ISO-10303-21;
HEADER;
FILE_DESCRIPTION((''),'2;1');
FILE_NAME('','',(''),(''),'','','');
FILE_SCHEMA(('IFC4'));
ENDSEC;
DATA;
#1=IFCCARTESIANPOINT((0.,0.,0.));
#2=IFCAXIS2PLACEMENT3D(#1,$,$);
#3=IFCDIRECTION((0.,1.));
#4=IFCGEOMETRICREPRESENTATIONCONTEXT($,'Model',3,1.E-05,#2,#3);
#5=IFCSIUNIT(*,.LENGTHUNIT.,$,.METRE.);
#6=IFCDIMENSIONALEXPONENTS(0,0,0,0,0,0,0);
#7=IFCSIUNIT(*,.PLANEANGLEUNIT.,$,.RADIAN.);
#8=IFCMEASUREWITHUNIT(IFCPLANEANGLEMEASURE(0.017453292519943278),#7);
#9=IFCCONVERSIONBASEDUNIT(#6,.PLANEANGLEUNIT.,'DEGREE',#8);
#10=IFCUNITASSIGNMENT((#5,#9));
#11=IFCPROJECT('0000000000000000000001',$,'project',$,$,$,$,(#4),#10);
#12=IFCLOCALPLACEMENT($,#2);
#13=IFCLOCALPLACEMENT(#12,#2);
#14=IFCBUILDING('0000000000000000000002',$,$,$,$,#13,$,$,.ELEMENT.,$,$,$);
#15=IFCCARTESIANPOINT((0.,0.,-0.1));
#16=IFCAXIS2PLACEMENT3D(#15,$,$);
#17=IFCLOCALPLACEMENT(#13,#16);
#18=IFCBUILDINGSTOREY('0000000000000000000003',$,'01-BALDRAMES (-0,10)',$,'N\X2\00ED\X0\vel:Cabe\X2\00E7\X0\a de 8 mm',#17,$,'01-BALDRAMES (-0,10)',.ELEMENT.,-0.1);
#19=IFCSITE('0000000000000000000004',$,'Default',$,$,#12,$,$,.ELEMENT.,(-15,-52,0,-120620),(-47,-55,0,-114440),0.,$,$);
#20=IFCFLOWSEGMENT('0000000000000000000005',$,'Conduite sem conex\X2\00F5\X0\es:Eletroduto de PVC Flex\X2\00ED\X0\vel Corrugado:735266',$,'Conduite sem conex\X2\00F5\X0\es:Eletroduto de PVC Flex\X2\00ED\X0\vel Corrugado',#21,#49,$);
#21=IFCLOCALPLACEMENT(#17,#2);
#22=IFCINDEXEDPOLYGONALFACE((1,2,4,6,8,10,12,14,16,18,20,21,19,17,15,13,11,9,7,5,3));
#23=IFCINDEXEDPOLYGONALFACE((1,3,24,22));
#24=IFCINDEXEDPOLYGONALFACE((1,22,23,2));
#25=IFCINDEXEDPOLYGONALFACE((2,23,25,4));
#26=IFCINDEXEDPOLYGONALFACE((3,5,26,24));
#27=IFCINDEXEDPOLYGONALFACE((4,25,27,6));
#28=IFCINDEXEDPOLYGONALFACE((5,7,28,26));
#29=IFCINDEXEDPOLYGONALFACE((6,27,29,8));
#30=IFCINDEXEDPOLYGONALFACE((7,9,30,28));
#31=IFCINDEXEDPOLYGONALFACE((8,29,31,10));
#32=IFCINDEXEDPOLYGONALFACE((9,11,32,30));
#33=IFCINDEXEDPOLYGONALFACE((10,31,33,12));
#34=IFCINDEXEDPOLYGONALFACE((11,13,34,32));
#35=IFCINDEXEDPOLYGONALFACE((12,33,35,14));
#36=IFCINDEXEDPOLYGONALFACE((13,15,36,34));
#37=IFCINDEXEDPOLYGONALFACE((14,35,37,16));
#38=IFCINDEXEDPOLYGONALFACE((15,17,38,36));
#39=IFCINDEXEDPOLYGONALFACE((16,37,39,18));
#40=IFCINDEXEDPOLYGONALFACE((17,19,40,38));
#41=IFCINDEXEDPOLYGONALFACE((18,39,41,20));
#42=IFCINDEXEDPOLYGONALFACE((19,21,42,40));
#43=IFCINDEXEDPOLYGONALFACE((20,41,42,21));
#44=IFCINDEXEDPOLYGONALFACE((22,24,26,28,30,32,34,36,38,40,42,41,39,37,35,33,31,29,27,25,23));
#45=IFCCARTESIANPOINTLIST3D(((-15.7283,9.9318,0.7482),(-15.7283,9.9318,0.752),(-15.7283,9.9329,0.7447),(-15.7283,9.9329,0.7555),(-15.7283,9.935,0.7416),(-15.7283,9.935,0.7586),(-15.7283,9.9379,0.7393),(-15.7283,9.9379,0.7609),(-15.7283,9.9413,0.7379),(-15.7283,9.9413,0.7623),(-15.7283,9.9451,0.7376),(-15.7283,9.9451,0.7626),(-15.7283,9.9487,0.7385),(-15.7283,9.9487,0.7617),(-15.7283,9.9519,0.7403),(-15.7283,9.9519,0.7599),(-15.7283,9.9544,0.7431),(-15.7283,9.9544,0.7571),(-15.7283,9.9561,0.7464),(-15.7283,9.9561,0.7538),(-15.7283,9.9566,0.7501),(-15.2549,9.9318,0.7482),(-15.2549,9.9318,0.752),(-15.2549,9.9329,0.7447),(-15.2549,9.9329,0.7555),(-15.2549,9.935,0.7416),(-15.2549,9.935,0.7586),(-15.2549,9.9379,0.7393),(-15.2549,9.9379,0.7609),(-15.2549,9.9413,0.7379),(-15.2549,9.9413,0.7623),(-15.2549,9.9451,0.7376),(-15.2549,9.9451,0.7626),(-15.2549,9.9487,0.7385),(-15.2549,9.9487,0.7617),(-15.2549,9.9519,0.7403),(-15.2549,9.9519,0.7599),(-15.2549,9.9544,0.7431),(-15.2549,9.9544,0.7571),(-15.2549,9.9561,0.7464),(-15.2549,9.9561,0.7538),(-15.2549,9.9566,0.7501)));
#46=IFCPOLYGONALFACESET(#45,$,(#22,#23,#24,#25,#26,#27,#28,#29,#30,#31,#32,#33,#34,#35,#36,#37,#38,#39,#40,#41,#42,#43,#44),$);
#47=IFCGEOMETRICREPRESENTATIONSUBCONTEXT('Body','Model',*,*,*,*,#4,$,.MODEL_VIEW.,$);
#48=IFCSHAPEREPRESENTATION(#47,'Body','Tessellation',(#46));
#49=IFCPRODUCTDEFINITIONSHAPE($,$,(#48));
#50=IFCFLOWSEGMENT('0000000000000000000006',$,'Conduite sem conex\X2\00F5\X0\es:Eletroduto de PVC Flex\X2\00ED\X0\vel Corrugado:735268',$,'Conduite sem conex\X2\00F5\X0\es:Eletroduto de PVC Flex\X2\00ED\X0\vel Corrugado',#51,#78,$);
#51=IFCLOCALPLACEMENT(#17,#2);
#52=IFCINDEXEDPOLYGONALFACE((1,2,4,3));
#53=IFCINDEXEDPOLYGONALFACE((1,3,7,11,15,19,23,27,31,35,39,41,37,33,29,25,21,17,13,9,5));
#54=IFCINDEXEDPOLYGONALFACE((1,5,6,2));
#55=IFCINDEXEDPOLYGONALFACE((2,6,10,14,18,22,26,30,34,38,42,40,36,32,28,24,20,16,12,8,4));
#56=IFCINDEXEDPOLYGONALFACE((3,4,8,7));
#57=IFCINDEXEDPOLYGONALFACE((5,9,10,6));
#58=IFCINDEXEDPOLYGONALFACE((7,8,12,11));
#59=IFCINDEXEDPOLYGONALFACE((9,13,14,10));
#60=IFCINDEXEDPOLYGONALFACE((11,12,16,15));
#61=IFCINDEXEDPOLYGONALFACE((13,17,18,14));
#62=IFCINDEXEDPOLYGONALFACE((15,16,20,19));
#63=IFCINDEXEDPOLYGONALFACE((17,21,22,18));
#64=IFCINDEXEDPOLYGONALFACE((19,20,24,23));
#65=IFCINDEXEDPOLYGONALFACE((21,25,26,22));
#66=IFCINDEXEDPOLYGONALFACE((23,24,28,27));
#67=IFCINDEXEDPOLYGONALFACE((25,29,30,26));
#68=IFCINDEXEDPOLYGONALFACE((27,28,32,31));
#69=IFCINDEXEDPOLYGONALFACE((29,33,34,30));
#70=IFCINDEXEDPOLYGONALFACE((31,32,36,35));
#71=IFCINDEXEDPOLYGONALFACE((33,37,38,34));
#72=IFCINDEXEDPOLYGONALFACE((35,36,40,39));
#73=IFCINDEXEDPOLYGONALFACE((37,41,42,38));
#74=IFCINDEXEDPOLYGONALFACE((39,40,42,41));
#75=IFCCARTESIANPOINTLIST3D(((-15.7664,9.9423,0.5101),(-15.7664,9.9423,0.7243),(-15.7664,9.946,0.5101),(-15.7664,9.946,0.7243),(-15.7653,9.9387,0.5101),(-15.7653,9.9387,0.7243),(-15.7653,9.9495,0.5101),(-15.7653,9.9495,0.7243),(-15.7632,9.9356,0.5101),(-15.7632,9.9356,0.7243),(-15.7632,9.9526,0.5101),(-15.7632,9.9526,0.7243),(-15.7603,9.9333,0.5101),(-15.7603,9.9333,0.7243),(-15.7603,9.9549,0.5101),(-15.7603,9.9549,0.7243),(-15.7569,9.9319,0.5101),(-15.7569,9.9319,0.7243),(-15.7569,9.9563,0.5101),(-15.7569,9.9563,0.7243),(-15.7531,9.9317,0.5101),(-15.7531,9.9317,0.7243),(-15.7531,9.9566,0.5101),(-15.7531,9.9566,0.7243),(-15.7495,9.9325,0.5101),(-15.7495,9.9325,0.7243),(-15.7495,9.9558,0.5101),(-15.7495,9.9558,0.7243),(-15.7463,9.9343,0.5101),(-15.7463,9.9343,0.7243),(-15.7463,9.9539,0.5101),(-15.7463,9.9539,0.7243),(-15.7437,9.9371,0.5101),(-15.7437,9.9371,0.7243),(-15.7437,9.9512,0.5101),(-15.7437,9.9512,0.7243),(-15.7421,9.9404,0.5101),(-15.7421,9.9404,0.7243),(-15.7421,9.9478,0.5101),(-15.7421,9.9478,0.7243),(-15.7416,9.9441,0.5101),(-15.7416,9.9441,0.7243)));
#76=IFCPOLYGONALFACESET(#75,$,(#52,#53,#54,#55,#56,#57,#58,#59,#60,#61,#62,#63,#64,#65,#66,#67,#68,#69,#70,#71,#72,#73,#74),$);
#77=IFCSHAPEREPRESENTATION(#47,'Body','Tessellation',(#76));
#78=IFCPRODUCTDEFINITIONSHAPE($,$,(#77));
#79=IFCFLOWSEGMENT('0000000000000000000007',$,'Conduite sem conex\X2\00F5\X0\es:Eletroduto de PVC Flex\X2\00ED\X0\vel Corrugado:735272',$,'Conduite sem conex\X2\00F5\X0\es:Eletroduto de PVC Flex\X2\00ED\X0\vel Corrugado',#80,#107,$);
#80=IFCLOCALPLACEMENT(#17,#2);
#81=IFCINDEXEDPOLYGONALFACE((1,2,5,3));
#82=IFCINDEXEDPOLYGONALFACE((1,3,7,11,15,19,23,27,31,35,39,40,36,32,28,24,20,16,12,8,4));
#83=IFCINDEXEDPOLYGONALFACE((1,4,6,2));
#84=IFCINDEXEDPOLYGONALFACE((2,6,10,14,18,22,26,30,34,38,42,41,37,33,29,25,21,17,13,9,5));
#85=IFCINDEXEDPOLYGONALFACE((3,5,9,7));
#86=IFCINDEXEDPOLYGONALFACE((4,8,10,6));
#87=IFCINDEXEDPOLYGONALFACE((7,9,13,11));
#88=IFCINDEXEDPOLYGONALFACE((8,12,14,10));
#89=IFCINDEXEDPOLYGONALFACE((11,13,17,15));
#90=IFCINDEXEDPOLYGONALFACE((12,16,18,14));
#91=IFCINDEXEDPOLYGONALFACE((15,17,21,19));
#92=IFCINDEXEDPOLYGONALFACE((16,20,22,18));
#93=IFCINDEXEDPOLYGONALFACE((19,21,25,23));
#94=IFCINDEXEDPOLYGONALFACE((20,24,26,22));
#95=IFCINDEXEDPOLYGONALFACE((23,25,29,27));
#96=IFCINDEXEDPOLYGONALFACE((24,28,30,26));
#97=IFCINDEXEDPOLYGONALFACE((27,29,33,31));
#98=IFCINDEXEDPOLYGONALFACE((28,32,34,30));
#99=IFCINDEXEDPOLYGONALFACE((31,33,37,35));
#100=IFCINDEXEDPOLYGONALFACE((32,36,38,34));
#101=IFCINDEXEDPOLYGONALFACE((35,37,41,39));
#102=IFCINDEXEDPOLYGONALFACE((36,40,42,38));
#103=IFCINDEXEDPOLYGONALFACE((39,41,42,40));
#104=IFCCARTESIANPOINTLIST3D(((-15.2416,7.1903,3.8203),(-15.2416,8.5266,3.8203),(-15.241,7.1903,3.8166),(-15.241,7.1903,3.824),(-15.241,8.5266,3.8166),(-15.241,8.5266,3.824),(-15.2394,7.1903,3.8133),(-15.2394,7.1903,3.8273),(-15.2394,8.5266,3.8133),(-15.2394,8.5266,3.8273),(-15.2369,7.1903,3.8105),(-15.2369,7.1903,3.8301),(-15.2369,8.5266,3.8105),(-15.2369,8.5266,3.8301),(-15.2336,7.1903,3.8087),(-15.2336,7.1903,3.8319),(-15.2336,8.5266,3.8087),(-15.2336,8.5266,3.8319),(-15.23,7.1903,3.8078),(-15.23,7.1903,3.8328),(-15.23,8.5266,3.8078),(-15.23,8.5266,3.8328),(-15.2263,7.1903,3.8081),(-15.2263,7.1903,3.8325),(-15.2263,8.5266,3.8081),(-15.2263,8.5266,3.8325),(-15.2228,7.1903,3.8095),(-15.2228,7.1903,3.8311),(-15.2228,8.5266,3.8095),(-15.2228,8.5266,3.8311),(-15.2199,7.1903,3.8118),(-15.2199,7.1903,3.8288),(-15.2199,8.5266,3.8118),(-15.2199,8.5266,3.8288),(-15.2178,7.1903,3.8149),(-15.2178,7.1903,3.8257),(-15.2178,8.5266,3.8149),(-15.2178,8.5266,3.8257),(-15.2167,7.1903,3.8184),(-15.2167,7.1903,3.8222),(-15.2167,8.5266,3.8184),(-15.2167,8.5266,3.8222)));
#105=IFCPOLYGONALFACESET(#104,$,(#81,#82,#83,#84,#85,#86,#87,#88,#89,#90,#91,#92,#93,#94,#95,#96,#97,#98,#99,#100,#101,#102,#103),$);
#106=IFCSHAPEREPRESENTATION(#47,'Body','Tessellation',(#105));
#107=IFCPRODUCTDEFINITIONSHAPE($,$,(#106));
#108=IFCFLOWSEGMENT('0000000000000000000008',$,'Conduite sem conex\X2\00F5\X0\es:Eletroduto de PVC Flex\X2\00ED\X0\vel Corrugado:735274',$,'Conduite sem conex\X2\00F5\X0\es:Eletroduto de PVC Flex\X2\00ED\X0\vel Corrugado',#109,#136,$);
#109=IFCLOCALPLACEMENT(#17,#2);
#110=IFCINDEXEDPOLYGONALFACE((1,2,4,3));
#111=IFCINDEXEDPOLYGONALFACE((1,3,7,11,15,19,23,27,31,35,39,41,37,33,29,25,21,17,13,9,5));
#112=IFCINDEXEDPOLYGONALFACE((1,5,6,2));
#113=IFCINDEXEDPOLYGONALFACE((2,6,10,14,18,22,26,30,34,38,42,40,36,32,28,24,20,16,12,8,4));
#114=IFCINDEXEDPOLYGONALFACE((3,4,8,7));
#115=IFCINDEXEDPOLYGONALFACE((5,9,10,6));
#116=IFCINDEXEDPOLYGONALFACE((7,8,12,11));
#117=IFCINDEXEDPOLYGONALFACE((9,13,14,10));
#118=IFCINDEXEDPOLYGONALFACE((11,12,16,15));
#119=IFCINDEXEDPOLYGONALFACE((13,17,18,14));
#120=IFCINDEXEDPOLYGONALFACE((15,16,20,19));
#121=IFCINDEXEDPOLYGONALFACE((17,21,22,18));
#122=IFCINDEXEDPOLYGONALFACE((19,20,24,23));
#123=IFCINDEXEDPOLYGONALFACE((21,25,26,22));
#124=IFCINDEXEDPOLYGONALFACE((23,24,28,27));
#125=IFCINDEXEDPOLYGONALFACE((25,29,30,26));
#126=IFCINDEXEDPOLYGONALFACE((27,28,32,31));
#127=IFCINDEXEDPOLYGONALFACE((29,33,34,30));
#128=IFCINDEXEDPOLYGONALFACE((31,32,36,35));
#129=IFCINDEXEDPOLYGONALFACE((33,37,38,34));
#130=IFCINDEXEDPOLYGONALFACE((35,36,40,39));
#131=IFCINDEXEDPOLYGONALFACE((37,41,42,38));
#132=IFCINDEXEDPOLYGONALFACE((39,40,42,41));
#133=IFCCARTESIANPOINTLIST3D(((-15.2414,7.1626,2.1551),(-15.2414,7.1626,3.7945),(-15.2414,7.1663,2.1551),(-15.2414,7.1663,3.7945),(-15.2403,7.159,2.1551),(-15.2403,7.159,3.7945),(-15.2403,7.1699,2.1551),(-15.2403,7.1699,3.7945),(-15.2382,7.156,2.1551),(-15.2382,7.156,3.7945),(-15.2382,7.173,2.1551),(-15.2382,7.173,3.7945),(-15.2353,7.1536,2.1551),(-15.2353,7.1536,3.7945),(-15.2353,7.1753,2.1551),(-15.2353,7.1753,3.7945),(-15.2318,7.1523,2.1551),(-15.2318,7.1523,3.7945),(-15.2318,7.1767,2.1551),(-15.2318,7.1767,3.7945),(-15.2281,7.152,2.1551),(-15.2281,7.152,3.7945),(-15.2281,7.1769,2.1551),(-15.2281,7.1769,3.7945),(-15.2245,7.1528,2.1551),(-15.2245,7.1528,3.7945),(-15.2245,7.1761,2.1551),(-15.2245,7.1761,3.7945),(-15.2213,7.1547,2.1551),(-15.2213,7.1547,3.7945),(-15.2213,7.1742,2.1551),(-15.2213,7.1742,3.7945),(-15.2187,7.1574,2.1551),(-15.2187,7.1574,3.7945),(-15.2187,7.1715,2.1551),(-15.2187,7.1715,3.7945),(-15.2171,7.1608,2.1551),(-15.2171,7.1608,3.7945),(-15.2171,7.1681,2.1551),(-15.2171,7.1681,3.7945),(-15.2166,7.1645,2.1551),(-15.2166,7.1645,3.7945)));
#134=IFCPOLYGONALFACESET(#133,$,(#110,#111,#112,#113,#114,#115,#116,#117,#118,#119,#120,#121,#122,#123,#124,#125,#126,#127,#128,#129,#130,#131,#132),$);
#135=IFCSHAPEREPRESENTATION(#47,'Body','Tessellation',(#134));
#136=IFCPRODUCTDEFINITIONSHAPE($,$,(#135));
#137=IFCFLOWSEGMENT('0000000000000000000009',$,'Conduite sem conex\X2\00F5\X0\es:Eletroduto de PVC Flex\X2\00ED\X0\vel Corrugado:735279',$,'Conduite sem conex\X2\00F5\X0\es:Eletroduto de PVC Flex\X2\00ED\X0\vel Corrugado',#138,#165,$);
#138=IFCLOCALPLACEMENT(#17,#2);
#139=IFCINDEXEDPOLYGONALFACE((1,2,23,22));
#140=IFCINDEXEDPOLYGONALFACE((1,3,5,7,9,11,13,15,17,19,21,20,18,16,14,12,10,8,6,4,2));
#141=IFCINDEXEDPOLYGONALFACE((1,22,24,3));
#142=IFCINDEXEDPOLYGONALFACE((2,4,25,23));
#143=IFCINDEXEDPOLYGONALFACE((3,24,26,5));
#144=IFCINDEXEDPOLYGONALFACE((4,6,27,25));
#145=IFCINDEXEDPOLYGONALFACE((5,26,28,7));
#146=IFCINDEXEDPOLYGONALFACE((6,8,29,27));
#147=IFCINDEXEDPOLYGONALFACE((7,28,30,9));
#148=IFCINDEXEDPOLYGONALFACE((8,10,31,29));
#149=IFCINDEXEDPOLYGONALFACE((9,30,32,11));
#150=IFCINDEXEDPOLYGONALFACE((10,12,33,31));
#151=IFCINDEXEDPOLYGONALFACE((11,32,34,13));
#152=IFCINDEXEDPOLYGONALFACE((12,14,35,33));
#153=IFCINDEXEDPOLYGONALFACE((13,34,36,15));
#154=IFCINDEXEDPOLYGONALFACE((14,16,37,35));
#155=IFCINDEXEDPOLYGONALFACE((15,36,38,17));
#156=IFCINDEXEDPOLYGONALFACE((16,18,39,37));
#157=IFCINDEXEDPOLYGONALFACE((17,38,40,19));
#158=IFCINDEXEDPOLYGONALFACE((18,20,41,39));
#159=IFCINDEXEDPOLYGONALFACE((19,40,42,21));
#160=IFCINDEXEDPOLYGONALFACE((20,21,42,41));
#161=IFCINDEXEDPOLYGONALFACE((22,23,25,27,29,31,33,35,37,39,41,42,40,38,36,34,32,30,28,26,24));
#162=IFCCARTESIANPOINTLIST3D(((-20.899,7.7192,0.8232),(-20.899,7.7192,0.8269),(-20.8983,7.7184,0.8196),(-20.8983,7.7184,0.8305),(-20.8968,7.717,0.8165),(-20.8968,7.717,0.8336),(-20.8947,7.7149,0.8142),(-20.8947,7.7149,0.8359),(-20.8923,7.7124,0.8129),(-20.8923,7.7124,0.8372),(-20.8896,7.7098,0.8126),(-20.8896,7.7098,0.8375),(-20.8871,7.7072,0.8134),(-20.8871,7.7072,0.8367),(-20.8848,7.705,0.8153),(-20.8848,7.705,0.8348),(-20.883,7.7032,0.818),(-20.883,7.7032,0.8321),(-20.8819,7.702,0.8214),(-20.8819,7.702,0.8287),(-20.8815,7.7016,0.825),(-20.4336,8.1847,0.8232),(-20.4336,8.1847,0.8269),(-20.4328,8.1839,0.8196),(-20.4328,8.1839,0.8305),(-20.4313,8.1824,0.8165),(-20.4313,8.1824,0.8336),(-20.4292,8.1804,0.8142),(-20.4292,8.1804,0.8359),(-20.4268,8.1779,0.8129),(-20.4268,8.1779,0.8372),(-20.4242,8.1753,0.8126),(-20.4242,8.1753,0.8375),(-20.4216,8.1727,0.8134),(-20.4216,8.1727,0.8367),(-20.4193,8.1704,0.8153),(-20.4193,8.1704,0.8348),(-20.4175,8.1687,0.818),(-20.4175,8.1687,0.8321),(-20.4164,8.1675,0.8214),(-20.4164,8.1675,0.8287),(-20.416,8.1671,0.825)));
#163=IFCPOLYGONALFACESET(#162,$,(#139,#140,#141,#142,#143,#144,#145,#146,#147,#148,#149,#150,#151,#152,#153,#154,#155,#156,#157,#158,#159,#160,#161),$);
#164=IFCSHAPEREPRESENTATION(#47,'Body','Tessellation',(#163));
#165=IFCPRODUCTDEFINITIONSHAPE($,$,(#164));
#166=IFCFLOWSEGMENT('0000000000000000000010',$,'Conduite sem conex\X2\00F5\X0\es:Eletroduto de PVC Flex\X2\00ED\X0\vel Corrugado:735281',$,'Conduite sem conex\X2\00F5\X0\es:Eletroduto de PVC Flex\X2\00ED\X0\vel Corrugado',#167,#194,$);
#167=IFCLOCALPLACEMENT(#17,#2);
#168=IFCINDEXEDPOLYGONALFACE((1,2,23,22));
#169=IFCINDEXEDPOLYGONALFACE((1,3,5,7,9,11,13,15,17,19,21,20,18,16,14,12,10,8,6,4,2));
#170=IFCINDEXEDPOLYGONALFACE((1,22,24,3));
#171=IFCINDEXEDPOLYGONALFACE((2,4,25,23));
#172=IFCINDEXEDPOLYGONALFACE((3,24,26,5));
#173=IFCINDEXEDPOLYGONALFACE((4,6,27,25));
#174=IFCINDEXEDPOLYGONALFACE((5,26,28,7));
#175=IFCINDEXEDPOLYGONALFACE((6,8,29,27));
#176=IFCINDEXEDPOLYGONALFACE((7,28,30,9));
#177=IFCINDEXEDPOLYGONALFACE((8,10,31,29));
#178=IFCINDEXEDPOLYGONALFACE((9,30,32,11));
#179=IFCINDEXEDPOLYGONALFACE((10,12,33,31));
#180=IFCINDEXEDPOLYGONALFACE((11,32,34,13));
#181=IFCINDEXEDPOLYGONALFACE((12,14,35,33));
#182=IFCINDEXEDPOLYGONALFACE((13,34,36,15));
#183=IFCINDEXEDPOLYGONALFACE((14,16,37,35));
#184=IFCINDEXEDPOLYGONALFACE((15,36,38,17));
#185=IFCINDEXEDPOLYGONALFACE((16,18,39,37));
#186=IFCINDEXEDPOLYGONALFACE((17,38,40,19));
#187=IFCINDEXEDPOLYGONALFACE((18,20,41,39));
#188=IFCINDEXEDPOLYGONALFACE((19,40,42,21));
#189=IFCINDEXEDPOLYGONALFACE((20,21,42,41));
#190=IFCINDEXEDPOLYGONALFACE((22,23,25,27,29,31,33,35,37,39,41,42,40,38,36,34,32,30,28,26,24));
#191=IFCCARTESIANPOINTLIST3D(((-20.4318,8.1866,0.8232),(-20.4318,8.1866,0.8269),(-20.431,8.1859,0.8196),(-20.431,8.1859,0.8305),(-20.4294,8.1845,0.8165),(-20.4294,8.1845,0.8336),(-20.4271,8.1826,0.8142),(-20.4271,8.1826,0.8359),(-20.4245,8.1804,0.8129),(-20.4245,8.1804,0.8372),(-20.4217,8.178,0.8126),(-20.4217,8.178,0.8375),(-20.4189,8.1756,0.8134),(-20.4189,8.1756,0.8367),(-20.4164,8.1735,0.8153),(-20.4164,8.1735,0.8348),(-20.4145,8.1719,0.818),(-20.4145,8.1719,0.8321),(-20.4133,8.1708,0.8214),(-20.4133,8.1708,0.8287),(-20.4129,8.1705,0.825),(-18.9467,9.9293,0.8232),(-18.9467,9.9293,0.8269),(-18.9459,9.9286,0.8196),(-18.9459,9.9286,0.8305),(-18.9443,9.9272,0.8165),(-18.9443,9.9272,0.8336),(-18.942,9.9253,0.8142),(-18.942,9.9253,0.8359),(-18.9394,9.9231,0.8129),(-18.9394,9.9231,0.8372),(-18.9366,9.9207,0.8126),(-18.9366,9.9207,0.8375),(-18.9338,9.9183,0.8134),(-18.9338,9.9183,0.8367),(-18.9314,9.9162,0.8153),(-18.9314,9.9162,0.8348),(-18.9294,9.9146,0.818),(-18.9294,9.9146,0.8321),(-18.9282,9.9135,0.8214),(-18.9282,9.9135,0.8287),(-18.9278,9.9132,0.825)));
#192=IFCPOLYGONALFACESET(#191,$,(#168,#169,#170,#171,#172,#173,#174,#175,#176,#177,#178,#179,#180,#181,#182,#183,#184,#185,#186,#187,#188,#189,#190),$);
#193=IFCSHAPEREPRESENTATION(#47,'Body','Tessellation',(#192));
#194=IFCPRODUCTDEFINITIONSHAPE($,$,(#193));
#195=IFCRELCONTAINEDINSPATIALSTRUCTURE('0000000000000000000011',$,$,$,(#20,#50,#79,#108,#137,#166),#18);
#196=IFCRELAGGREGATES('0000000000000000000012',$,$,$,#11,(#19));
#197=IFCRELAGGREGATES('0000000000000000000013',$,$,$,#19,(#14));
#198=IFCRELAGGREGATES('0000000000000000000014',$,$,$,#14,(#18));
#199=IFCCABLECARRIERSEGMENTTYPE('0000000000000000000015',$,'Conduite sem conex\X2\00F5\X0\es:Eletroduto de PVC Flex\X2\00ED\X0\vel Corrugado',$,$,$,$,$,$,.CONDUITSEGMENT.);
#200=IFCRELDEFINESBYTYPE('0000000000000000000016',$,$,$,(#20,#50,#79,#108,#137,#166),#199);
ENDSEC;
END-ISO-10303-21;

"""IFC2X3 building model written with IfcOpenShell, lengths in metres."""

from ifc_helpers import new_model, entity, si_unit, converted_unit, direction, frame, frame_2d, origin, origin_2d_with_axis, place, context, subcontext, project, spatial, circle, extrude, type_object, element, save


model = new_model("IFC2X3")

# Units and contexts
model_context = context("Model", 3, precision=1e-05, world=origin(), true_north=direction((0.0, 1.0)))
body_context = subcontext(model_context, "Body", "Model", "MODEL_VIEW")
ifc_project = project(units=[si_unit("LENGTHUNIT", "METRE"), converted_unit("PLANEANGLEUNIT", "DEGREE", entity("IfcPlaneAngleMeasure", 0.017453292519943278), si_unit("PLANEANGLEUNIT", "RADIAN"), dimensions=[0, 0, 0, 0, 0, 0, 0])], contexts=[model_context])

# Site, building, storey
site_placement = place(None, origin())
site = spatial("IfcSite", under=ifc_project, at=site_placement, Name="Default", CompositionType="ELEMENT", RefLatitude=(-15, -52, 0, -120620), RefLongitude=(-47, -55, 0, -114440), RefElevation=0.0)
building_placement = place(site_placement, origin())
building = spatial("IfcBuilding", under=site, at=building_placement, CompositionType="ELEMENT")
storey_placement = place(building_placement, frame((0.0, 0.0, -0.1)))
storey = spatial("IfcBuildingStorey", under=building, at=storey_placement, Name="01-BALDRAMES (-0,10)", ObjectType="Nível:Cabeça de 8 mm", LongName="01-BALDRAMES (-0,10)", CompositionType="ELEMENT", Elevation=-0.1)

# Flow segments
cable_carrier_segment_type = type_object("IfcCableCarrierSegmentType", Name="Conduite sem conexões:Eletroduto de PVC Flexível Corrugado", PredefinedType="CONDUITSEGMENT")
flow_segment_1_placement = place(storey_placement, origin())
element("IfcFlowSegment", 1, at=flow_segment_1_placement, inside=storey, type_object=cable_carrier_segment_type, Name="Conduite sem conexões:Eletroduto de PVC Flexível Corrugado:735266", ObjectType="Conduite sem conexões:Eletroduto de PVC Flexível Corrugado", context=body_context, shape_type="SweptSolid", body=[
    extrude(circle(Radius=0.0125, at=origin_2d_with_axis()), frame((-15.7283, 9.9441, 0.7501), z_axis=(1.0, 0.0, 0.0), x_axis=(0.0, 1.0, 0.0)), (0.0, 0.0, 1.0), 0.4734),
])
flow_segment_2_placement = place(storey_placement, origin())
element("IfcFlowSegment", 2, at=flow_segment_2_placement, inside=storey, type_object=cable_carrier_segment_type, Name="Conduite sem conexões:Eletroduto de PVC Flexível Corrugado:735268", ObjectType="Conduite sem conexões:Eletroduto de PVC Flexível Corrugado", context=body_context, shape_type="SweptSolid", body=[
    extrude(circle(Radius=0.0125, at=origin_2d_with_axis()), frame((-15.7541, 9.9441, 0.5101)), (0.0, 0.0, 1.0), 0.2142),
])
flow_segment_3_placement = place(storey_placement, origin())
element("IfcFlowSegment", 3, at=flow_segment_3_placement, inside=storey, type_object=cable_carrier_segment_type, Name="Conduite sem conexões:Eletroduto de PVC Flexível Corrugado:735272", ObjectType="Conduite sem conexões:Eletroduto de PVC Flexível Corrugado", context=body_context, shape_type="SweptSolid", body=[
    extrude(circle(Radius=0.0125, at=frame_2d((0.0, 0.0), x_axis=(1.0, 0.0))), frame((-15.2291, 7.1903, 3.8203), z_axis=(0.0, 1.0, 0.0), x_axis=(-1.0, 0.0, 0.0)), (0.0, 0.0, 1.0), 1.3363),
])
flow_segment_4_placement = place(storey_placement, origin())
element("IfcFlowSegment", 4, at=flow_segment_4_placement, inside=storey, type_object=cable_carrier_segment_type, Name="Conduite sem conexões:Eletroduto de PVC Flexível Corrugado:735274", ObjectType="Conduite sem conexões:Eletroduto de PVC Flexível Corrugado", context=body_context, shape_type="SweptSolid", body=[
    extrude(circle(Radius=0.0125, at=origin_2d_with_axis()), frame((-15.2291, 7.1645, 2.1551)), (0.0, 0.0, 1.0), 1.6394),
])
flow_segment_5_placement = place(storey_placement, origin())
element("IfcFlowSegment", 5, at=flow_segment_5_placement, inside=storey, type_object=cable_carrier_segment_type, Name="Conduite sem conexões:Eletroduto de PVC Flexível Corrugado:735279", ObjectType="Conduite sem conexões:Eletroduto de PVC Flexível Corrugado", context=body_context, shape_type="SweptSolid", body=[
    extrude(circle(Radius=0.0125, at=origin_2d_with_axis()), frame((-20.8903, 7.7105, 0.825), z_axis=(0.707107, 0.707107, 0.0), x_axis=(0.707107, -0.707107, 0.0)), (0.0, 0.0, 1.0), 0.6583),
])
flow_segment_6_placement = place(storey_placement, origin())
element("IfcFlowSegment", 6, at=flow_segment_6_placement, inside=storey, type_object=cable_carrier_segment_type, Name="Conduite sem conexões:Eletroduto de PVC Flexível Corrugado:735281", ObjectType="Conduite sem conexões:Eletroduto de PVC Flexível Corrugado", context=body_context, shape_type="SweptSolid", body=[
    extrude(circle(Radius=0.0125, at=frame_2d((0.0, 0.0), x_axis=(1.0, 0.0))), frame((-20.4224, 8.1786, 0.825), z_axis=(0.648615, 0.761116, 0.0), x_axis=(0.761116, -0.648615, 0.0)), (0.0, 0.0, 1.0), 2.2896),
])

save(model, "model.ifc")
